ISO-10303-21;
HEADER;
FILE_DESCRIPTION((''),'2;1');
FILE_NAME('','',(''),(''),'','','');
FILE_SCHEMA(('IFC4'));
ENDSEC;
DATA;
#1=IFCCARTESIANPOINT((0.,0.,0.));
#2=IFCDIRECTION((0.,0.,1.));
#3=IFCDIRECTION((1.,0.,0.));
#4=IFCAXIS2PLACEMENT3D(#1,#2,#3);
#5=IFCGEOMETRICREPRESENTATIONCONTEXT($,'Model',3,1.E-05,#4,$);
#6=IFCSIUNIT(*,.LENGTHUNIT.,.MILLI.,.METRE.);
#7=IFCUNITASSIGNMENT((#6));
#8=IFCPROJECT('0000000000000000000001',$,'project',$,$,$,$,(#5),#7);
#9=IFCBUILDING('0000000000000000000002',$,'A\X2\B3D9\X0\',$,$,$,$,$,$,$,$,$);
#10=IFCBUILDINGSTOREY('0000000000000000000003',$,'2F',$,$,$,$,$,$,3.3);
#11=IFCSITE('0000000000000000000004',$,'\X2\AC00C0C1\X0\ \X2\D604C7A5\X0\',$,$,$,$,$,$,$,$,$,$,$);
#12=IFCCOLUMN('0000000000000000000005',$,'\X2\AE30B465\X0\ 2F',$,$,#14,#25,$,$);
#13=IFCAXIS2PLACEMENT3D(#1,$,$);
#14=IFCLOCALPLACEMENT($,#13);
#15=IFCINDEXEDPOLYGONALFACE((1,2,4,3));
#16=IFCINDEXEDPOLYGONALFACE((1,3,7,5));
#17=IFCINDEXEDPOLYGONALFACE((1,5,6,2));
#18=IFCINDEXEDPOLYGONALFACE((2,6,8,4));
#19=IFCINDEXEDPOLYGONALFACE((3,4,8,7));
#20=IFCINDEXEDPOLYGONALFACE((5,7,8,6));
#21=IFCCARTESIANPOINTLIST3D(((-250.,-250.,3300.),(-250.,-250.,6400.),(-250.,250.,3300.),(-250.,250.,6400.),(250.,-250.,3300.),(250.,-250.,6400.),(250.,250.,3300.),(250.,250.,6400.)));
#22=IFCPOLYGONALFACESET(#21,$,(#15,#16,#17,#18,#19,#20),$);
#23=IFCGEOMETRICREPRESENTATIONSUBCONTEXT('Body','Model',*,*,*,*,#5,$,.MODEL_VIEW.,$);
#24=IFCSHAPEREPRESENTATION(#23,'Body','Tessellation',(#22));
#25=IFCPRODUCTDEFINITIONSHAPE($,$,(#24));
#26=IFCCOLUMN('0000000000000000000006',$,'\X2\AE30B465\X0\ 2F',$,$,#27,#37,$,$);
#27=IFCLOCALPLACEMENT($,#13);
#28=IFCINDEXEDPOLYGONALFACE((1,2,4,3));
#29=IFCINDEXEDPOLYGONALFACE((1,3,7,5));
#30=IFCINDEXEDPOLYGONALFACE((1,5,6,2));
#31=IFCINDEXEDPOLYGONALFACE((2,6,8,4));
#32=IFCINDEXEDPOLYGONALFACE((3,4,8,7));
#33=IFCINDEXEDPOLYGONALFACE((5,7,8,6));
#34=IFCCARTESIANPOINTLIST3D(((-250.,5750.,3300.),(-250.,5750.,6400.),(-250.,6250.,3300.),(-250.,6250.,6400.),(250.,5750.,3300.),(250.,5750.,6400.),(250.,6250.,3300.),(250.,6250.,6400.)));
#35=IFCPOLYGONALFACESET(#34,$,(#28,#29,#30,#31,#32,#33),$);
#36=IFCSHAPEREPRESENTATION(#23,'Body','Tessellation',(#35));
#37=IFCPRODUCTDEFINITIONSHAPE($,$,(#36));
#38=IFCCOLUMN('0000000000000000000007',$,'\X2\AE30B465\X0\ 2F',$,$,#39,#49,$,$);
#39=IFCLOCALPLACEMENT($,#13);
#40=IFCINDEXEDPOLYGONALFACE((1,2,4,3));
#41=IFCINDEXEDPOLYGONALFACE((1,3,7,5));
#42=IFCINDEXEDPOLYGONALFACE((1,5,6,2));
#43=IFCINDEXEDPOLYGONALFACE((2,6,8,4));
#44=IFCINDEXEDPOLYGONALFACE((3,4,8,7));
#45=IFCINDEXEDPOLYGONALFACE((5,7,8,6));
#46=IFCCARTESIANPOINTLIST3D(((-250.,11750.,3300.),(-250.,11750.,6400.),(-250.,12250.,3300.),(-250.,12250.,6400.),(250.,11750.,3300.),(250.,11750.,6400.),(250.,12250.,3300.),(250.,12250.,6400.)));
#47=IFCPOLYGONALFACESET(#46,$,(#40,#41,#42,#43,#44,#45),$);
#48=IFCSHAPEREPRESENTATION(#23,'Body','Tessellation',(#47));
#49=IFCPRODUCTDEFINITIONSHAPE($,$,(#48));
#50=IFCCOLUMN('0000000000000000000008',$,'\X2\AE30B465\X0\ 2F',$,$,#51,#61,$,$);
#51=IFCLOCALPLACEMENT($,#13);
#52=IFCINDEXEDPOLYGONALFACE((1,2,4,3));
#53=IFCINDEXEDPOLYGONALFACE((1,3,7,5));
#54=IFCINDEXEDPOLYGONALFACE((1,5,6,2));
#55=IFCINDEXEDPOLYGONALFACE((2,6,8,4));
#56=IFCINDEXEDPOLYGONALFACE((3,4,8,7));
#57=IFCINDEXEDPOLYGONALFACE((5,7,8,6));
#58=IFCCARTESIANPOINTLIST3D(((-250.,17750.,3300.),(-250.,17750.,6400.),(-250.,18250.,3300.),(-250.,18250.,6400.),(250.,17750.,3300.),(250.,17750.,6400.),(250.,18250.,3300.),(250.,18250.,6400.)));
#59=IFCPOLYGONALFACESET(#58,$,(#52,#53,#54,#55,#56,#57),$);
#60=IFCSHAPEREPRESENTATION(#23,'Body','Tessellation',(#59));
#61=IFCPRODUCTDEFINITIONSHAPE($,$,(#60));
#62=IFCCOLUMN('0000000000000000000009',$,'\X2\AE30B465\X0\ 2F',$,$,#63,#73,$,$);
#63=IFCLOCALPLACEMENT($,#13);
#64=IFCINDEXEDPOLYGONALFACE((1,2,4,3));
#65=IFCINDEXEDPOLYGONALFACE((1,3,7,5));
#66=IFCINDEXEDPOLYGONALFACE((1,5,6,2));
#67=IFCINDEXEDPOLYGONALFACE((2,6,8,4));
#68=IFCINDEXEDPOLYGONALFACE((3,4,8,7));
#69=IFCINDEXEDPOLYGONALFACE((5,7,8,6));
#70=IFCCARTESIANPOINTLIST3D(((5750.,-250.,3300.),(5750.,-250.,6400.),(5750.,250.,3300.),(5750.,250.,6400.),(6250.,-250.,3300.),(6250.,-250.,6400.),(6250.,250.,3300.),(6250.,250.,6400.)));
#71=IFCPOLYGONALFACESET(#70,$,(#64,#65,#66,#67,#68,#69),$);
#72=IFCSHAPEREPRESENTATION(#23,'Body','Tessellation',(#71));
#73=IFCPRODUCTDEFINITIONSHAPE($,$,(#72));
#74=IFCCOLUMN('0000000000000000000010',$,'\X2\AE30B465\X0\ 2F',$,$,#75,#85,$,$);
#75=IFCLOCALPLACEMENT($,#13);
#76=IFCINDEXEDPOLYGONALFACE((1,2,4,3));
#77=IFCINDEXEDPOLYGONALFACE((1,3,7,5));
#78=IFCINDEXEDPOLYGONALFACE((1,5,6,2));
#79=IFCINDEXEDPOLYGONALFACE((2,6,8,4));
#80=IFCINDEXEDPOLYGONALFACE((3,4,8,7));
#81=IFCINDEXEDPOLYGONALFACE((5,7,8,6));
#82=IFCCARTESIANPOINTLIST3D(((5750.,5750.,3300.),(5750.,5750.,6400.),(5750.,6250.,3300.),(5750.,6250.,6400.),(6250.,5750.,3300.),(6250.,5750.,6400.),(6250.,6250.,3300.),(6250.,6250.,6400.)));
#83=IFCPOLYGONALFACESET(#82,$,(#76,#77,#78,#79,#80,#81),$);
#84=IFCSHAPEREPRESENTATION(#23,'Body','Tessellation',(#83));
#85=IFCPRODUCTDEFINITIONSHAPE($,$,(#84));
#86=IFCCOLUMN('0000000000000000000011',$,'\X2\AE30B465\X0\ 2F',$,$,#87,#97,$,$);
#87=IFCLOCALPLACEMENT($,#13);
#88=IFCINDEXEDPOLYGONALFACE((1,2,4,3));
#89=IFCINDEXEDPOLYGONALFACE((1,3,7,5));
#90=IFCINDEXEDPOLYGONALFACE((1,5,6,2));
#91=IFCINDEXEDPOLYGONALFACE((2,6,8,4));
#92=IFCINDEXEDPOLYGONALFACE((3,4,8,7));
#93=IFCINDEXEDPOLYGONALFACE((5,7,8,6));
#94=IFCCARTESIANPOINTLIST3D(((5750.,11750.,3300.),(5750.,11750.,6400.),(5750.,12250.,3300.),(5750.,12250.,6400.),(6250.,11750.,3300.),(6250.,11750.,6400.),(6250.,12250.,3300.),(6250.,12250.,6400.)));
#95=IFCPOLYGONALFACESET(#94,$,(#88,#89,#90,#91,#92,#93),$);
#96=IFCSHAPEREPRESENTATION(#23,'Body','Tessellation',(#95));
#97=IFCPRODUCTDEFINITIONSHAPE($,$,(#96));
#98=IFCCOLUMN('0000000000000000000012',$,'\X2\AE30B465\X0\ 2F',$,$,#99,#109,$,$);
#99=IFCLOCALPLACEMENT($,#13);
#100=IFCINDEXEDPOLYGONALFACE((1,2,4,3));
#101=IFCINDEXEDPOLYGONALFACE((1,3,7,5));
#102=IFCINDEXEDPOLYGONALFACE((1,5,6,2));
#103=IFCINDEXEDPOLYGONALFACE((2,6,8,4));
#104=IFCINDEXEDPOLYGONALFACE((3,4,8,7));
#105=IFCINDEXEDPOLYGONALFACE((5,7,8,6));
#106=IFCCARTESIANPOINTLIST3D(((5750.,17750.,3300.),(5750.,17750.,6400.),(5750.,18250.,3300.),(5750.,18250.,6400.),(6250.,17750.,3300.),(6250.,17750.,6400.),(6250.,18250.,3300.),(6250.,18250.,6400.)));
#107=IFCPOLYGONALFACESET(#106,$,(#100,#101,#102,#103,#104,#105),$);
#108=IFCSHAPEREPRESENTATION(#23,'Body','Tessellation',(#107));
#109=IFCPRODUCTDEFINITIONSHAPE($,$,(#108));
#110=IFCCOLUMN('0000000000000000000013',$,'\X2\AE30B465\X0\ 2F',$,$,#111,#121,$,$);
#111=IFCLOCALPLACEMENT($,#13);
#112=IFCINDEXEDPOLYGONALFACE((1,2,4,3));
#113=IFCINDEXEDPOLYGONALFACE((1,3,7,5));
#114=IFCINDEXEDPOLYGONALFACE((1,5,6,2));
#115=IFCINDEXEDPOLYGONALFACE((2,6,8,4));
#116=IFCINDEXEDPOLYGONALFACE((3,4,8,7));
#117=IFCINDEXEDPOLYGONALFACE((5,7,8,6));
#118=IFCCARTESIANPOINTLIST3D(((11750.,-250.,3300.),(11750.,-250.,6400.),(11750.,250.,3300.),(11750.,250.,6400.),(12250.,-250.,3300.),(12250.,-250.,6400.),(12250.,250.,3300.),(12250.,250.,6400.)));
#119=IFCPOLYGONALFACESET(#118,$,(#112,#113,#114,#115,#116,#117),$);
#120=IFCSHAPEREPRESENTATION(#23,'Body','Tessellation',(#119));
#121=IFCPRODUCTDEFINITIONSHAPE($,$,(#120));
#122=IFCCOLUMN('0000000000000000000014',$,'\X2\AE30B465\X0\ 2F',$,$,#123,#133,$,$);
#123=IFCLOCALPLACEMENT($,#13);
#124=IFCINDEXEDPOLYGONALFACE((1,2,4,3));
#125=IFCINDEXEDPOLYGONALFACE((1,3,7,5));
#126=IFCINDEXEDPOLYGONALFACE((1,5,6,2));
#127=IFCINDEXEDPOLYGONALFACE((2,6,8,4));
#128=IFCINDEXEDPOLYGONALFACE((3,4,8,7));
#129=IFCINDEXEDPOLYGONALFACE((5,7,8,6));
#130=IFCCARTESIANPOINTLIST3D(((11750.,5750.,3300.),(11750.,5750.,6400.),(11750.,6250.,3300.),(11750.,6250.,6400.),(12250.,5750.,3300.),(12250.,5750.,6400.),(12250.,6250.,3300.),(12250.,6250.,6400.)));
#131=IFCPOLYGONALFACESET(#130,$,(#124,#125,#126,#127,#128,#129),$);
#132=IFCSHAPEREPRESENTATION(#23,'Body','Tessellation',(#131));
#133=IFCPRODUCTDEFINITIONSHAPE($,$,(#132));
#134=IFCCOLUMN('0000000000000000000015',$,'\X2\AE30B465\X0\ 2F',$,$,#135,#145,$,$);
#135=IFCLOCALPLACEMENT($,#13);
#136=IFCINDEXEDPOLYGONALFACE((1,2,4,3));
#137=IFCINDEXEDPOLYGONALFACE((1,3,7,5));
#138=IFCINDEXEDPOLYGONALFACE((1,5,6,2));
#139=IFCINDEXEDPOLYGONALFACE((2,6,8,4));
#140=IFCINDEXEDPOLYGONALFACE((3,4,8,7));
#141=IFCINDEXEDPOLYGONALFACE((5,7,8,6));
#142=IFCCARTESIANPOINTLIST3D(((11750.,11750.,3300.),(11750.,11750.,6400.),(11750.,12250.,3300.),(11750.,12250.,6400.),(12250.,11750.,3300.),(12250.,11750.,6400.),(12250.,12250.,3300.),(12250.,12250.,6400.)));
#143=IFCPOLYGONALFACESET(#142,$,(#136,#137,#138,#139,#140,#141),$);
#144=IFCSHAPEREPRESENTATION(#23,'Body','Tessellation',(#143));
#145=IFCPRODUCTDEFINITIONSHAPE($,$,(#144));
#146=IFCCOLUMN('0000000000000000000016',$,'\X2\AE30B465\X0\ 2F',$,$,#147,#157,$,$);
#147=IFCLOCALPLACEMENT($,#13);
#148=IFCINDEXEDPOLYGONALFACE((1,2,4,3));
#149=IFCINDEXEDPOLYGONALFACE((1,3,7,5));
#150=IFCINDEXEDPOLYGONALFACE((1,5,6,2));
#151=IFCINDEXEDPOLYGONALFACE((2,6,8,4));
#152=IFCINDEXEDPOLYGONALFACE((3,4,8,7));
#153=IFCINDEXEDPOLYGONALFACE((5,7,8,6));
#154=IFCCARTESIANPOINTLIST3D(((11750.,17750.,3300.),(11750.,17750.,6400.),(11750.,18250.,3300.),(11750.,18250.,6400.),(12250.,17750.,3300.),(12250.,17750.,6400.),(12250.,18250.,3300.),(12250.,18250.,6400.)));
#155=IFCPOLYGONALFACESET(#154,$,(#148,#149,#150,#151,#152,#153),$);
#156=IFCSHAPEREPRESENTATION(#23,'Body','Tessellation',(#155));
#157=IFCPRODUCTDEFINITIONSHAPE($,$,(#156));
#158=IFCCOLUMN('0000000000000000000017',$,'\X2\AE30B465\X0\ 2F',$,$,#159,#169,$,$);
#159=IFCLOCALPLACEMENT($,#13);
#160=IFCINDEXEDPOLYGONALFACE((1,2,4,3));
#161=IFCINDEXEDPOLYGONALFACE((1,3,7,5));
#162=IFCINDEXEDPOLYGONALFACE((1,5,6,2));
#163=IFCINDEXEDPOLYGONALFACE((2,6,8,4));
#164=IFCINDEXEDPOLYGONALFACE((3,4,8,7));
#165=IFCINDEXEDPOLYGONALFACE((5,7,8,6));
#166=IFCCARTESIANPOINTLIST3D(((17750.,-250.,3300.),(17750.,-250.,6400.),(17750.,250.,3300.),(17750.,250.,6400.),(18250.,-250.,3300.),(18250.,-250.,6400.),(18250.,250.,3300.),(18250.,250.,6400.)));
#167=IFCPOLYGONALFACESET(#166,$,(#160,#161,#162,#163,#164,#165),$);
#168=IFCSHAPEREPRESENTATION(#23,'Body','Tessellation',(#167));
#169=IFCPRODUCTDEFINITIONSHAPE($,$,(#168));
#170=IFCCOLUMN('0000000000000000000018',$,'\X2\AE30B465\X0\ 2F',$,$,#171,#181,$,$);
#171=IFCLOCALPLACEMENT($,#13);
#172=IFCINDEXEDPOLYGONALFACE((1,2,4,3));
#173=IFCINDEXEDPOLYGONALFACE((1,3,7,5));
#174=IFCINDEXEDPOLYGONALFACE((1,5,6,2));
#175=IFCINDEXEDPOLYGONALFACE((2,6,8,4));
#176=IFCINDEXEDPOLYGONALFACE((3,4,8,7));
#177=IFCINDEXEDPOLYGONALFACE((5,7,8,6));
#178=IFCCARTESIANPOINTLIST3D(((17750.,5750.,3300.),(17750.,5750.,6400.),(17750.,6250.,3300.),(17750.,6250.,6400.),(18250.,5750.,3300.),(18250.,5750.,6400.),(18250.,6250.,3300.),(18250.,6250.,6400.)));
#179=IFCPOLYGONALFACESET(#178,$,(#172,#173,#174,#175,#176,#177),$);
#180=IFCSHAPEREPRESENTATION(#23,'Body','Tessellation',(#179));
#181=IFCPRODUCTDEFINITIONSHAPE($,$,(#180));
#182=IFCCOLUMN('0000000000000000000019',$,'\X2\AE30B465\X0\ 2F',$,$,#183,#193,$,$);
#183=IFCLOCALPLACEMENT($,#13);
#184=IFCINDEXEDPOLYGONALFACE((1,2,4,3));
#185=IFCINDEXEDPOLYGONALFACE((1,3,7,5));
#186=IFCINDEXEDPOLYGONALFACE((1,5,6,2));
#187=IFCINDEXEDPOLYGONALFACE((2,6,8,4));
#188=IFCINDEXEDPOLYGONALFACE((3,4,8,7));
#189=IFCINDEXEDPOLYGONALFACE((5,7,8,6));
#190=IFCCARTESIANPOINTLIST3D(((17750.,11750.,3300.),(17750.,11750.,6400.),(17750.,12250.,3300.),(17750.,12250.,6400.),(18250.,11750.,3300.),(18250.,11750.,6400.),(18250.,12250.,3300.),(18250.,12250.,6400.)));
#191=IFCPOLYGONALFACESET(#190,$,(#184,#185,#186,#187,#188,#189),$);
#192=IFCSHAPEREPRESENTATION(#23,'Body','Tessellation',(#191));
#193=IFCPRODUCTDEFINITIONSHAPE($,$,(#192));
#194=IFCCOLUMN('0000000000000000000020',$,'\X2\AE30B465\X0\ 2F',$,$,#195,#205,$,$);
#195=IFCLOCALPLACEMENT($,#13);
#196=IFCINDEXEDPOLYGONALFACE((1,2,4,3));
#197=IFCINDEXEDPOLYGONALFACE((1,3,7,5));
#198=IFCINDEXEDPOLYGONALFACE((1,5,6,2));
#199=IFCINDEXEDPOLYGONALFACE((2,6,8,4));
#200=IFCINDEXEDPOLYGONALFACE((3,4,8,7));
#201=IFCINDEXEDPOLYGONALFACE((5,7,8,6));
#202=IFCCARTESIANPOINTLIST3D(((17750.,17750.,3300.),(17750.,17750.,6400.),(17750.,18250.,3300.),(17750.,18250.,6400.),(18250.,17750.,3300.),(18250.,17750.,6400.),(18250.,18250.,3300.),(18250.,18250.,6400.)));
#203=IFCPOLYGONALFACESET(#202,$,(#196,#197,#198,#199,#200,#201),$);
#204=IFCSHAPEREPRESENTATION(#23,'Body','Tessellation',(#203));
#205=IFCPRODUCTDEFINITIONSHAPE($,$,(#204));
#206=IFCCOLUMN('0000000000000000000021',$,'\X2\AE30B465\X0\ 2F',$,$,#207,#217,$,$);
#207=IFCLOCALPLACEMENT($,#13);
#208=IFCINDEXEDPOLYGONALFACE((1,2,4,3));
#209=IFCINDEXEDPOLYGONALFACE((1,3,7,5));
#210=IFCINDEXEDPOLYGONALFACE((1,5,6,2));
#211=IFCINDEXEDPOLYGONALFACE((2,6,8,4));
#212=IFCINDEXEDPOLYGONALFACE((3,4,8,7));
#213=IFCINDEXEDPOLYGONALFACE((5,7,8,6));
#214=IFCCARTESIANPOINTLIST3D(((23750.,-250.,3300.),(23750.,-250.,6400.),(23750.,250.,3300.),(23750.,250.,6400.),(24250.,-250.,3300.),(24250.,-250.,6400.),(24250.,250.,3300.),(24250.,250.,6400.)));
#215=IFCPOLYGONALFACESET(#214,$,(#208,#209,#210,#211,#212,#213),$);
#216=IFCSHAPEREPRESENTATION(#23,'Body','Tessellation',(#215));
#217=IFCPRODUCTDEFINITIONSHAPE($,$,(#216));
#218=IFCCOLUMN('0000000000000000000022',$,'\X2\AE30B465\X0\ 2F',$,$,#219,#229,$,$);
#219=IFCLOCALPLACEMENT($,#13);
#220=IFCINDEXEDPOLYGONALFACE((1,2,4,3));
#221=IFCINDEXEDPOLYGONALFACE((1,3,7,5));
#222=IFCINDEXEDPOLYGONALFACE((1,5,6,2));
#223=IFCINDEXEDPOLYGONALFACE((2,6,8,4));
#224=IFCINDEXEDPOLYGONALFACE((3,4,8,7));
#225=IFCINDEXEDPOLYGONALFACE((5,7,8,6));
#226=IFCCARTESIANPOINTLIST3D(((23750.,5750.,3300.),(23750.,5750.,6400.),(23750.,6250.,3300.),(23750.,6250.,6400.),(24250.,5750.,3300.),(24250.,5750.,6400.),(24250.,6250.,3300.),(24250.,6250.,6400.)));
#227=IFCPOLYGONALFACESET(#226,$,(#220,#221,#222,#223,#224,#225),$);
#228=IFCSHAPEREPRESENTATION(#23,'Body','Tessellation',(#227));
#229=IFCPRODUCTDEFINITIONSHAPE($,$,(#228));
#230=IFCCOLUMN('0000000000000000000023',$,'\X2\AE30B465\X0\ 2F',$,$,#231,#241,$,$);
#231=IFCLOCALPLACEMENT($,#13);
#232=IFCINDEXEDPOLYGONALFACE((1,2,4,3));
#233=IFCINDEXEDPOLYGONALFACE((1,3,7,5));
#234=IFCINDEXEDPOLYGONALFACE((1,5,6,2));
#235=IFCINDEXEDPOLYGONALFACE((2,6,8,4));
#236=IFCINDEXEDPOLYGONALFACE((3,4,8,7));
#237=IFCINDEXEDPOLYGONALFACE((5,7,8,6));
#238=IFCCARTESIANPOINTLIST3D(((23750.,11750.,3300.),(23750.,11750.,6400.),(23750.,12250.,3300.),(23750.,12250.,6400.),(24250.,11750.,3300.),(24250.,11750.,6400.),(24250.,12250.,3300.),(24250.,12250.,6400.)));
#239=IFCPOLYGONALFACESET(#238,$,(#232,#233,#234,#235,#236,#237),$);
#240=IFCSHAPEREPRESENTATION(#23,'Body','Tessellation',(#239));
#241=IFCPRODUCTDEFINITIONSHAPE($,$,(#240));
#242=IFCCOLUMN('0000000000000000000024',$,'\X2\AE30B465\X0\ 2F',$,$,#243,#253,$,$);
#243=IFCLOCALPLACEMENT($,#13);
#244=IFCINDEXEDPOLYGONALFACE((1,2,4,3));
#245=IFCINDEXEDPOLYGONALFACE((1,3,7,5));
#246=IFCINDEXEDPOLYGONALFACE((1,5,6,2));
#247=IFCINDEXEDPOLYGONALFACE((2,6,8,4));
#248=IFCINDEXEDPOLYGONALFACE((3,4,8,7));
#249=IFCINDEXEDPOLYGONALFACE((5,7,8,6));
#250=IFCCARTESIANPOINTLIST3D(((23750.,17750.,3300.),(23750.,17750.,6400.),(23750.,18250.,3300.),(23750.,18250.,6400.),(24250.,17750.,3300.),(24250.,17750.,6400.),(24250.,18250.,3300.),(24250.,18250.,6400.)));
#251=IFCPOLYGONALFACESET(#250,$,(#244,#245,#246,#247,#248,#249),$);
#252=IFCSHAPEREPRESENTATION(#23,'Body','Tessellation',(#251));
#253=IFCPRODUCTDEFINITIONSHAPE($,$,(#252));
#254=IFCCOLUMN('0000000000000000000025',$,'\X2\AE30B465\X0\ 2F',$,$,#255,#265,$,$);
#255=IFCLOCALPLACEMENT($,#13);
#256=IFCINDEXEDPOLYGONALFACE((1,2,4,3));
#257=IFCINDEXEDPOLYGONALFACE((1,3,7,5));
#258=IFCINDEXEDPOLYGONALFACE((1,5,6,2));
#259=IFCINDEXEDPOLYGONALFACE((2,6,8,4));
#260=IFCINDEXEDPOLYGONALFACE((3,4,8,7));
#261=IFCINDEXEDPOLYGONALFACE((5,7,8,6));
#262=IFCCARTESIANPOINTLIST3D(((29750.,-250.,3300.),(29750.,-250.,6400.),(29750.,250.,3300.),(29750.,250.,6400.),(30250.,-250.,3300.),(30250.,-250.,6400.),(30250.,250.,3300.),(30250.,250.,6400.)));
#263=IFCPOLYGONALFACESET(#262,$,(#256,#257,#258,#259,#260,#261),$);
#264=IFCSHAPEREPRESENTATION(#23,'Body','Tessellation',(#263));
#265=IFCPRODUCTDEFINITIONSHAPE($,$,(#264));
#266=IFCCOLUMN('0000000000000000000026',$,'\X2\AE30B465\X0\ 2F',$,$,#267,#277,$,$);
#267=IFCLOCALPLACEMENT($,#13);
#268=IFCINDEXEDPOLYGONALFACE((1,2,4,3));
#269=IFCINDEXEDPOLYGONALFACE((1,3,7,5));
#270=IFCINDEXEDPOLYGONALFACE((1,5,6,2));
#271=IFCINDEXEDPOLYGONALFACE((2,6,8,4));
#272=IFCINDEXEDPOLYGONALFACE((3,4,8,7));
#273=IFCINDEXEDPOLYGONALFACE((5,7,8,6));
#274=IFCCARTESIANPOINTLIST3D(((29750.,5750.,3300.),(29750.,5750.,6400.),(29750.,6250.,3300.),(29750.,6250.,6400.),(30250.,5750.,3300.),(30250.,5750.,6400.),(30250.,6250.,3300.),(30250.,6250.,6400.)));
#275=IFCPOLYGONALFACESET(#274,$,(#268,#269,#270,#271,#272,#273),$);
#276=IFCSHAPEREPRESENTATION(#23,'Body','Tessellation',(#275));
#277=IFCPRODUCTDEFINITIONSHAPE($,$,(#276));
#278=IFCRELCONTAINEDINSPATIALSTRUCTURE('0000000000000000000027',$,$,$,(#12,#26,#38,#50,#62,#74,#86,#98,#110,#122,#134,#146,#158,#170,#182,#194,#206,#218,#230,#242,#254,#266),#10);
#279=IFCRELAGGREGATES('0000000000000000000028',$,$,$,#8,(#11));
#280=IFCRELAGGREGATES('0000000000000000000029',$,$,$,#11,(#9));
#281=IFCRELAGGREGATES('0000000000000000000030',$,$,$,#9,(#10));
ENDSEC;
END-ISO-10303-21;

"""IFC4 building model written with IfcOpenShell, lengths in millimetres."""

from ifc_helpers import new_model, si_unit, frame, origin_with_axes, place, context, subcontext, project, spatial, indexed_curve, outline, extrude, element, save


model = new_model("IFC4")

# Units and contexts
model_context = context("Model", 3, precision=1e-05, world=origin_with_axes())
body_context = subcontext(model_context, "Body", "Model", "MODEL_VIEW")
ifc_project = project(units=[si_unit("LENGTHUNIT", "METRE", prefix="MILLI")], contexts=[model_context])

# Site, building, storey
site = spatial("IfcSite", under=ifc_project, Name="가상 현장")
building = spatial("IfcBuilding", under=site, Name="A동")
storey = spatial("IfcBuildingStorey", under=building, Name="2F", Elevation=3.3)

# Columns
for number, where, z_axis, x_axis, name in (
    (1, (-250.0, -250.0, 3300.0), (0.0, 0.0, 1.0), (1.0, 0.0, 0.0), "기둥 2F"),
    (2, (-250.0, 5750.0, 3300.0), (0.0, 0.0, 1.0), (1.0, 0.0, 0.0), "기둥 2F"),
    (3, (-250.0, 11750.0, 3300.0), (0.0, 0.0, 1.0), (1.0, 0.0, 0.0), "기둥 2F"),
    (4, (-250.0, 17750.0, 3300.0), (0.0, 0.0, 1.0), (1.0, 0.0, 0.0), "기둥 2F"),
    (5, (5750.0, -250.0, 3300.0), (0.0, 0.0, 1.0), (1.0, 0.0, 0.0), "기둥 2F"),
    (6, (5750.0, 5750.0, 3300.0), (0.0, 0.0, 1.0), (1.0, 0.0, 0.0), "기둥 2F"),
    (7, (5750.0, 11750.0, 3300.0), (0.0, 0.0, 1.0), (1.0, 0.0, 0.0), "기둥 2F"),
    (8, (5750.0, 17750.0, 3300.0), (0.0, 0.0, 1.0), (1.0, 0.0, 0.0), "기둥 2F"),
    (9, (11750.0, -250.0, 3300.0), (0.0, 0.0, 1.0), (1.0, 0.0, 0.0), "기둥 2F"),
    (10, (11750.0, 5750.0, 3300.0), (0.0, 0.0, 1.0), (1.0, 0.0, 0.0), "기둥 2F"),
    (11, (11750.0, 11750.0, 3300.0), (0.0, 0.0, 1.0), (1.0, 0.0, 0.0), "기둥 2F"),
    (12, (11750.0, 17750.0, 3300.0), (0.0, 0.0, 1.0), (1.0, 0.0, 0.0), "기둥 2F"),
    (13, (17750.0, -250.0, 3300.0), (0.0, 0.0, 1.0), (1.0, 0.0, 0.0), "기둥 2F"),
    (14, (17750.0, 5750.0, 3300.0), (0.0, 0.0, 1.0), (1.0, 0.0, 0.0), "기둥 2F"),
    (15, (17750.0, 11750.0, 3300.0), (0.0, 0.0, 1.0), (1.0, 0.0, 0.0), "기둥 2F"),
    (16, (17750.0, 17750.0, 3300.0), (0.0, 0.0, 1.0), (1.0, 0.0, 0.0), "기둥 2F"),
    (17, (23750.0, -250.0, 3300.0), (0.0, 0.0, 1.0), (1.0, 0.0, 0.0), "기둥 2F"),
    (18, (23750.0, 5750.0, 3300.0), (0.0, 0.0, 1.0), (1.0, 0.0, 0.0), "기둥 2F"),
    (19, (23750.0, 11750.0, 3300.0), (0.0, 0.0, 1.0), (1.0, 0.0, 0.0), "기둥 2F"),
    (20, (23750.0, 17750.0, 3300.0), (0.0, 0.0, 1.0), (1.0, 0.0, 0.0), "기둥 2F"),
    (21, (29750.0, -250.0, 3300.0), (0.0, 0.0, 1.0), (1.0, 0.0, 0.0), "기둥 2F"),
    (22, (29750.0, 5750.0, 3300.0), (0.0, 0.0, 1.0), (1.0, 0.0, 0.0), "기둥 2F"),
):
    element("IfcColumn", number, at=place(None, frame(where, z_axis=z_axis, x_axis=x_axis)), inside=storey, Name=name, context=body_context, shape_type="SweptSolid", body=[
        extrude(outline(indexed_curve([(0.0, 0.0), (0.0, 500.0), (500.0, 500.0), (500.0, 0.0), (0.0, 0.0)], self_intersect=False)), origin_with_axes(), (0.0, 0.0, 1.0), 3100.0),
    ])

save(model, "model.ifc")
